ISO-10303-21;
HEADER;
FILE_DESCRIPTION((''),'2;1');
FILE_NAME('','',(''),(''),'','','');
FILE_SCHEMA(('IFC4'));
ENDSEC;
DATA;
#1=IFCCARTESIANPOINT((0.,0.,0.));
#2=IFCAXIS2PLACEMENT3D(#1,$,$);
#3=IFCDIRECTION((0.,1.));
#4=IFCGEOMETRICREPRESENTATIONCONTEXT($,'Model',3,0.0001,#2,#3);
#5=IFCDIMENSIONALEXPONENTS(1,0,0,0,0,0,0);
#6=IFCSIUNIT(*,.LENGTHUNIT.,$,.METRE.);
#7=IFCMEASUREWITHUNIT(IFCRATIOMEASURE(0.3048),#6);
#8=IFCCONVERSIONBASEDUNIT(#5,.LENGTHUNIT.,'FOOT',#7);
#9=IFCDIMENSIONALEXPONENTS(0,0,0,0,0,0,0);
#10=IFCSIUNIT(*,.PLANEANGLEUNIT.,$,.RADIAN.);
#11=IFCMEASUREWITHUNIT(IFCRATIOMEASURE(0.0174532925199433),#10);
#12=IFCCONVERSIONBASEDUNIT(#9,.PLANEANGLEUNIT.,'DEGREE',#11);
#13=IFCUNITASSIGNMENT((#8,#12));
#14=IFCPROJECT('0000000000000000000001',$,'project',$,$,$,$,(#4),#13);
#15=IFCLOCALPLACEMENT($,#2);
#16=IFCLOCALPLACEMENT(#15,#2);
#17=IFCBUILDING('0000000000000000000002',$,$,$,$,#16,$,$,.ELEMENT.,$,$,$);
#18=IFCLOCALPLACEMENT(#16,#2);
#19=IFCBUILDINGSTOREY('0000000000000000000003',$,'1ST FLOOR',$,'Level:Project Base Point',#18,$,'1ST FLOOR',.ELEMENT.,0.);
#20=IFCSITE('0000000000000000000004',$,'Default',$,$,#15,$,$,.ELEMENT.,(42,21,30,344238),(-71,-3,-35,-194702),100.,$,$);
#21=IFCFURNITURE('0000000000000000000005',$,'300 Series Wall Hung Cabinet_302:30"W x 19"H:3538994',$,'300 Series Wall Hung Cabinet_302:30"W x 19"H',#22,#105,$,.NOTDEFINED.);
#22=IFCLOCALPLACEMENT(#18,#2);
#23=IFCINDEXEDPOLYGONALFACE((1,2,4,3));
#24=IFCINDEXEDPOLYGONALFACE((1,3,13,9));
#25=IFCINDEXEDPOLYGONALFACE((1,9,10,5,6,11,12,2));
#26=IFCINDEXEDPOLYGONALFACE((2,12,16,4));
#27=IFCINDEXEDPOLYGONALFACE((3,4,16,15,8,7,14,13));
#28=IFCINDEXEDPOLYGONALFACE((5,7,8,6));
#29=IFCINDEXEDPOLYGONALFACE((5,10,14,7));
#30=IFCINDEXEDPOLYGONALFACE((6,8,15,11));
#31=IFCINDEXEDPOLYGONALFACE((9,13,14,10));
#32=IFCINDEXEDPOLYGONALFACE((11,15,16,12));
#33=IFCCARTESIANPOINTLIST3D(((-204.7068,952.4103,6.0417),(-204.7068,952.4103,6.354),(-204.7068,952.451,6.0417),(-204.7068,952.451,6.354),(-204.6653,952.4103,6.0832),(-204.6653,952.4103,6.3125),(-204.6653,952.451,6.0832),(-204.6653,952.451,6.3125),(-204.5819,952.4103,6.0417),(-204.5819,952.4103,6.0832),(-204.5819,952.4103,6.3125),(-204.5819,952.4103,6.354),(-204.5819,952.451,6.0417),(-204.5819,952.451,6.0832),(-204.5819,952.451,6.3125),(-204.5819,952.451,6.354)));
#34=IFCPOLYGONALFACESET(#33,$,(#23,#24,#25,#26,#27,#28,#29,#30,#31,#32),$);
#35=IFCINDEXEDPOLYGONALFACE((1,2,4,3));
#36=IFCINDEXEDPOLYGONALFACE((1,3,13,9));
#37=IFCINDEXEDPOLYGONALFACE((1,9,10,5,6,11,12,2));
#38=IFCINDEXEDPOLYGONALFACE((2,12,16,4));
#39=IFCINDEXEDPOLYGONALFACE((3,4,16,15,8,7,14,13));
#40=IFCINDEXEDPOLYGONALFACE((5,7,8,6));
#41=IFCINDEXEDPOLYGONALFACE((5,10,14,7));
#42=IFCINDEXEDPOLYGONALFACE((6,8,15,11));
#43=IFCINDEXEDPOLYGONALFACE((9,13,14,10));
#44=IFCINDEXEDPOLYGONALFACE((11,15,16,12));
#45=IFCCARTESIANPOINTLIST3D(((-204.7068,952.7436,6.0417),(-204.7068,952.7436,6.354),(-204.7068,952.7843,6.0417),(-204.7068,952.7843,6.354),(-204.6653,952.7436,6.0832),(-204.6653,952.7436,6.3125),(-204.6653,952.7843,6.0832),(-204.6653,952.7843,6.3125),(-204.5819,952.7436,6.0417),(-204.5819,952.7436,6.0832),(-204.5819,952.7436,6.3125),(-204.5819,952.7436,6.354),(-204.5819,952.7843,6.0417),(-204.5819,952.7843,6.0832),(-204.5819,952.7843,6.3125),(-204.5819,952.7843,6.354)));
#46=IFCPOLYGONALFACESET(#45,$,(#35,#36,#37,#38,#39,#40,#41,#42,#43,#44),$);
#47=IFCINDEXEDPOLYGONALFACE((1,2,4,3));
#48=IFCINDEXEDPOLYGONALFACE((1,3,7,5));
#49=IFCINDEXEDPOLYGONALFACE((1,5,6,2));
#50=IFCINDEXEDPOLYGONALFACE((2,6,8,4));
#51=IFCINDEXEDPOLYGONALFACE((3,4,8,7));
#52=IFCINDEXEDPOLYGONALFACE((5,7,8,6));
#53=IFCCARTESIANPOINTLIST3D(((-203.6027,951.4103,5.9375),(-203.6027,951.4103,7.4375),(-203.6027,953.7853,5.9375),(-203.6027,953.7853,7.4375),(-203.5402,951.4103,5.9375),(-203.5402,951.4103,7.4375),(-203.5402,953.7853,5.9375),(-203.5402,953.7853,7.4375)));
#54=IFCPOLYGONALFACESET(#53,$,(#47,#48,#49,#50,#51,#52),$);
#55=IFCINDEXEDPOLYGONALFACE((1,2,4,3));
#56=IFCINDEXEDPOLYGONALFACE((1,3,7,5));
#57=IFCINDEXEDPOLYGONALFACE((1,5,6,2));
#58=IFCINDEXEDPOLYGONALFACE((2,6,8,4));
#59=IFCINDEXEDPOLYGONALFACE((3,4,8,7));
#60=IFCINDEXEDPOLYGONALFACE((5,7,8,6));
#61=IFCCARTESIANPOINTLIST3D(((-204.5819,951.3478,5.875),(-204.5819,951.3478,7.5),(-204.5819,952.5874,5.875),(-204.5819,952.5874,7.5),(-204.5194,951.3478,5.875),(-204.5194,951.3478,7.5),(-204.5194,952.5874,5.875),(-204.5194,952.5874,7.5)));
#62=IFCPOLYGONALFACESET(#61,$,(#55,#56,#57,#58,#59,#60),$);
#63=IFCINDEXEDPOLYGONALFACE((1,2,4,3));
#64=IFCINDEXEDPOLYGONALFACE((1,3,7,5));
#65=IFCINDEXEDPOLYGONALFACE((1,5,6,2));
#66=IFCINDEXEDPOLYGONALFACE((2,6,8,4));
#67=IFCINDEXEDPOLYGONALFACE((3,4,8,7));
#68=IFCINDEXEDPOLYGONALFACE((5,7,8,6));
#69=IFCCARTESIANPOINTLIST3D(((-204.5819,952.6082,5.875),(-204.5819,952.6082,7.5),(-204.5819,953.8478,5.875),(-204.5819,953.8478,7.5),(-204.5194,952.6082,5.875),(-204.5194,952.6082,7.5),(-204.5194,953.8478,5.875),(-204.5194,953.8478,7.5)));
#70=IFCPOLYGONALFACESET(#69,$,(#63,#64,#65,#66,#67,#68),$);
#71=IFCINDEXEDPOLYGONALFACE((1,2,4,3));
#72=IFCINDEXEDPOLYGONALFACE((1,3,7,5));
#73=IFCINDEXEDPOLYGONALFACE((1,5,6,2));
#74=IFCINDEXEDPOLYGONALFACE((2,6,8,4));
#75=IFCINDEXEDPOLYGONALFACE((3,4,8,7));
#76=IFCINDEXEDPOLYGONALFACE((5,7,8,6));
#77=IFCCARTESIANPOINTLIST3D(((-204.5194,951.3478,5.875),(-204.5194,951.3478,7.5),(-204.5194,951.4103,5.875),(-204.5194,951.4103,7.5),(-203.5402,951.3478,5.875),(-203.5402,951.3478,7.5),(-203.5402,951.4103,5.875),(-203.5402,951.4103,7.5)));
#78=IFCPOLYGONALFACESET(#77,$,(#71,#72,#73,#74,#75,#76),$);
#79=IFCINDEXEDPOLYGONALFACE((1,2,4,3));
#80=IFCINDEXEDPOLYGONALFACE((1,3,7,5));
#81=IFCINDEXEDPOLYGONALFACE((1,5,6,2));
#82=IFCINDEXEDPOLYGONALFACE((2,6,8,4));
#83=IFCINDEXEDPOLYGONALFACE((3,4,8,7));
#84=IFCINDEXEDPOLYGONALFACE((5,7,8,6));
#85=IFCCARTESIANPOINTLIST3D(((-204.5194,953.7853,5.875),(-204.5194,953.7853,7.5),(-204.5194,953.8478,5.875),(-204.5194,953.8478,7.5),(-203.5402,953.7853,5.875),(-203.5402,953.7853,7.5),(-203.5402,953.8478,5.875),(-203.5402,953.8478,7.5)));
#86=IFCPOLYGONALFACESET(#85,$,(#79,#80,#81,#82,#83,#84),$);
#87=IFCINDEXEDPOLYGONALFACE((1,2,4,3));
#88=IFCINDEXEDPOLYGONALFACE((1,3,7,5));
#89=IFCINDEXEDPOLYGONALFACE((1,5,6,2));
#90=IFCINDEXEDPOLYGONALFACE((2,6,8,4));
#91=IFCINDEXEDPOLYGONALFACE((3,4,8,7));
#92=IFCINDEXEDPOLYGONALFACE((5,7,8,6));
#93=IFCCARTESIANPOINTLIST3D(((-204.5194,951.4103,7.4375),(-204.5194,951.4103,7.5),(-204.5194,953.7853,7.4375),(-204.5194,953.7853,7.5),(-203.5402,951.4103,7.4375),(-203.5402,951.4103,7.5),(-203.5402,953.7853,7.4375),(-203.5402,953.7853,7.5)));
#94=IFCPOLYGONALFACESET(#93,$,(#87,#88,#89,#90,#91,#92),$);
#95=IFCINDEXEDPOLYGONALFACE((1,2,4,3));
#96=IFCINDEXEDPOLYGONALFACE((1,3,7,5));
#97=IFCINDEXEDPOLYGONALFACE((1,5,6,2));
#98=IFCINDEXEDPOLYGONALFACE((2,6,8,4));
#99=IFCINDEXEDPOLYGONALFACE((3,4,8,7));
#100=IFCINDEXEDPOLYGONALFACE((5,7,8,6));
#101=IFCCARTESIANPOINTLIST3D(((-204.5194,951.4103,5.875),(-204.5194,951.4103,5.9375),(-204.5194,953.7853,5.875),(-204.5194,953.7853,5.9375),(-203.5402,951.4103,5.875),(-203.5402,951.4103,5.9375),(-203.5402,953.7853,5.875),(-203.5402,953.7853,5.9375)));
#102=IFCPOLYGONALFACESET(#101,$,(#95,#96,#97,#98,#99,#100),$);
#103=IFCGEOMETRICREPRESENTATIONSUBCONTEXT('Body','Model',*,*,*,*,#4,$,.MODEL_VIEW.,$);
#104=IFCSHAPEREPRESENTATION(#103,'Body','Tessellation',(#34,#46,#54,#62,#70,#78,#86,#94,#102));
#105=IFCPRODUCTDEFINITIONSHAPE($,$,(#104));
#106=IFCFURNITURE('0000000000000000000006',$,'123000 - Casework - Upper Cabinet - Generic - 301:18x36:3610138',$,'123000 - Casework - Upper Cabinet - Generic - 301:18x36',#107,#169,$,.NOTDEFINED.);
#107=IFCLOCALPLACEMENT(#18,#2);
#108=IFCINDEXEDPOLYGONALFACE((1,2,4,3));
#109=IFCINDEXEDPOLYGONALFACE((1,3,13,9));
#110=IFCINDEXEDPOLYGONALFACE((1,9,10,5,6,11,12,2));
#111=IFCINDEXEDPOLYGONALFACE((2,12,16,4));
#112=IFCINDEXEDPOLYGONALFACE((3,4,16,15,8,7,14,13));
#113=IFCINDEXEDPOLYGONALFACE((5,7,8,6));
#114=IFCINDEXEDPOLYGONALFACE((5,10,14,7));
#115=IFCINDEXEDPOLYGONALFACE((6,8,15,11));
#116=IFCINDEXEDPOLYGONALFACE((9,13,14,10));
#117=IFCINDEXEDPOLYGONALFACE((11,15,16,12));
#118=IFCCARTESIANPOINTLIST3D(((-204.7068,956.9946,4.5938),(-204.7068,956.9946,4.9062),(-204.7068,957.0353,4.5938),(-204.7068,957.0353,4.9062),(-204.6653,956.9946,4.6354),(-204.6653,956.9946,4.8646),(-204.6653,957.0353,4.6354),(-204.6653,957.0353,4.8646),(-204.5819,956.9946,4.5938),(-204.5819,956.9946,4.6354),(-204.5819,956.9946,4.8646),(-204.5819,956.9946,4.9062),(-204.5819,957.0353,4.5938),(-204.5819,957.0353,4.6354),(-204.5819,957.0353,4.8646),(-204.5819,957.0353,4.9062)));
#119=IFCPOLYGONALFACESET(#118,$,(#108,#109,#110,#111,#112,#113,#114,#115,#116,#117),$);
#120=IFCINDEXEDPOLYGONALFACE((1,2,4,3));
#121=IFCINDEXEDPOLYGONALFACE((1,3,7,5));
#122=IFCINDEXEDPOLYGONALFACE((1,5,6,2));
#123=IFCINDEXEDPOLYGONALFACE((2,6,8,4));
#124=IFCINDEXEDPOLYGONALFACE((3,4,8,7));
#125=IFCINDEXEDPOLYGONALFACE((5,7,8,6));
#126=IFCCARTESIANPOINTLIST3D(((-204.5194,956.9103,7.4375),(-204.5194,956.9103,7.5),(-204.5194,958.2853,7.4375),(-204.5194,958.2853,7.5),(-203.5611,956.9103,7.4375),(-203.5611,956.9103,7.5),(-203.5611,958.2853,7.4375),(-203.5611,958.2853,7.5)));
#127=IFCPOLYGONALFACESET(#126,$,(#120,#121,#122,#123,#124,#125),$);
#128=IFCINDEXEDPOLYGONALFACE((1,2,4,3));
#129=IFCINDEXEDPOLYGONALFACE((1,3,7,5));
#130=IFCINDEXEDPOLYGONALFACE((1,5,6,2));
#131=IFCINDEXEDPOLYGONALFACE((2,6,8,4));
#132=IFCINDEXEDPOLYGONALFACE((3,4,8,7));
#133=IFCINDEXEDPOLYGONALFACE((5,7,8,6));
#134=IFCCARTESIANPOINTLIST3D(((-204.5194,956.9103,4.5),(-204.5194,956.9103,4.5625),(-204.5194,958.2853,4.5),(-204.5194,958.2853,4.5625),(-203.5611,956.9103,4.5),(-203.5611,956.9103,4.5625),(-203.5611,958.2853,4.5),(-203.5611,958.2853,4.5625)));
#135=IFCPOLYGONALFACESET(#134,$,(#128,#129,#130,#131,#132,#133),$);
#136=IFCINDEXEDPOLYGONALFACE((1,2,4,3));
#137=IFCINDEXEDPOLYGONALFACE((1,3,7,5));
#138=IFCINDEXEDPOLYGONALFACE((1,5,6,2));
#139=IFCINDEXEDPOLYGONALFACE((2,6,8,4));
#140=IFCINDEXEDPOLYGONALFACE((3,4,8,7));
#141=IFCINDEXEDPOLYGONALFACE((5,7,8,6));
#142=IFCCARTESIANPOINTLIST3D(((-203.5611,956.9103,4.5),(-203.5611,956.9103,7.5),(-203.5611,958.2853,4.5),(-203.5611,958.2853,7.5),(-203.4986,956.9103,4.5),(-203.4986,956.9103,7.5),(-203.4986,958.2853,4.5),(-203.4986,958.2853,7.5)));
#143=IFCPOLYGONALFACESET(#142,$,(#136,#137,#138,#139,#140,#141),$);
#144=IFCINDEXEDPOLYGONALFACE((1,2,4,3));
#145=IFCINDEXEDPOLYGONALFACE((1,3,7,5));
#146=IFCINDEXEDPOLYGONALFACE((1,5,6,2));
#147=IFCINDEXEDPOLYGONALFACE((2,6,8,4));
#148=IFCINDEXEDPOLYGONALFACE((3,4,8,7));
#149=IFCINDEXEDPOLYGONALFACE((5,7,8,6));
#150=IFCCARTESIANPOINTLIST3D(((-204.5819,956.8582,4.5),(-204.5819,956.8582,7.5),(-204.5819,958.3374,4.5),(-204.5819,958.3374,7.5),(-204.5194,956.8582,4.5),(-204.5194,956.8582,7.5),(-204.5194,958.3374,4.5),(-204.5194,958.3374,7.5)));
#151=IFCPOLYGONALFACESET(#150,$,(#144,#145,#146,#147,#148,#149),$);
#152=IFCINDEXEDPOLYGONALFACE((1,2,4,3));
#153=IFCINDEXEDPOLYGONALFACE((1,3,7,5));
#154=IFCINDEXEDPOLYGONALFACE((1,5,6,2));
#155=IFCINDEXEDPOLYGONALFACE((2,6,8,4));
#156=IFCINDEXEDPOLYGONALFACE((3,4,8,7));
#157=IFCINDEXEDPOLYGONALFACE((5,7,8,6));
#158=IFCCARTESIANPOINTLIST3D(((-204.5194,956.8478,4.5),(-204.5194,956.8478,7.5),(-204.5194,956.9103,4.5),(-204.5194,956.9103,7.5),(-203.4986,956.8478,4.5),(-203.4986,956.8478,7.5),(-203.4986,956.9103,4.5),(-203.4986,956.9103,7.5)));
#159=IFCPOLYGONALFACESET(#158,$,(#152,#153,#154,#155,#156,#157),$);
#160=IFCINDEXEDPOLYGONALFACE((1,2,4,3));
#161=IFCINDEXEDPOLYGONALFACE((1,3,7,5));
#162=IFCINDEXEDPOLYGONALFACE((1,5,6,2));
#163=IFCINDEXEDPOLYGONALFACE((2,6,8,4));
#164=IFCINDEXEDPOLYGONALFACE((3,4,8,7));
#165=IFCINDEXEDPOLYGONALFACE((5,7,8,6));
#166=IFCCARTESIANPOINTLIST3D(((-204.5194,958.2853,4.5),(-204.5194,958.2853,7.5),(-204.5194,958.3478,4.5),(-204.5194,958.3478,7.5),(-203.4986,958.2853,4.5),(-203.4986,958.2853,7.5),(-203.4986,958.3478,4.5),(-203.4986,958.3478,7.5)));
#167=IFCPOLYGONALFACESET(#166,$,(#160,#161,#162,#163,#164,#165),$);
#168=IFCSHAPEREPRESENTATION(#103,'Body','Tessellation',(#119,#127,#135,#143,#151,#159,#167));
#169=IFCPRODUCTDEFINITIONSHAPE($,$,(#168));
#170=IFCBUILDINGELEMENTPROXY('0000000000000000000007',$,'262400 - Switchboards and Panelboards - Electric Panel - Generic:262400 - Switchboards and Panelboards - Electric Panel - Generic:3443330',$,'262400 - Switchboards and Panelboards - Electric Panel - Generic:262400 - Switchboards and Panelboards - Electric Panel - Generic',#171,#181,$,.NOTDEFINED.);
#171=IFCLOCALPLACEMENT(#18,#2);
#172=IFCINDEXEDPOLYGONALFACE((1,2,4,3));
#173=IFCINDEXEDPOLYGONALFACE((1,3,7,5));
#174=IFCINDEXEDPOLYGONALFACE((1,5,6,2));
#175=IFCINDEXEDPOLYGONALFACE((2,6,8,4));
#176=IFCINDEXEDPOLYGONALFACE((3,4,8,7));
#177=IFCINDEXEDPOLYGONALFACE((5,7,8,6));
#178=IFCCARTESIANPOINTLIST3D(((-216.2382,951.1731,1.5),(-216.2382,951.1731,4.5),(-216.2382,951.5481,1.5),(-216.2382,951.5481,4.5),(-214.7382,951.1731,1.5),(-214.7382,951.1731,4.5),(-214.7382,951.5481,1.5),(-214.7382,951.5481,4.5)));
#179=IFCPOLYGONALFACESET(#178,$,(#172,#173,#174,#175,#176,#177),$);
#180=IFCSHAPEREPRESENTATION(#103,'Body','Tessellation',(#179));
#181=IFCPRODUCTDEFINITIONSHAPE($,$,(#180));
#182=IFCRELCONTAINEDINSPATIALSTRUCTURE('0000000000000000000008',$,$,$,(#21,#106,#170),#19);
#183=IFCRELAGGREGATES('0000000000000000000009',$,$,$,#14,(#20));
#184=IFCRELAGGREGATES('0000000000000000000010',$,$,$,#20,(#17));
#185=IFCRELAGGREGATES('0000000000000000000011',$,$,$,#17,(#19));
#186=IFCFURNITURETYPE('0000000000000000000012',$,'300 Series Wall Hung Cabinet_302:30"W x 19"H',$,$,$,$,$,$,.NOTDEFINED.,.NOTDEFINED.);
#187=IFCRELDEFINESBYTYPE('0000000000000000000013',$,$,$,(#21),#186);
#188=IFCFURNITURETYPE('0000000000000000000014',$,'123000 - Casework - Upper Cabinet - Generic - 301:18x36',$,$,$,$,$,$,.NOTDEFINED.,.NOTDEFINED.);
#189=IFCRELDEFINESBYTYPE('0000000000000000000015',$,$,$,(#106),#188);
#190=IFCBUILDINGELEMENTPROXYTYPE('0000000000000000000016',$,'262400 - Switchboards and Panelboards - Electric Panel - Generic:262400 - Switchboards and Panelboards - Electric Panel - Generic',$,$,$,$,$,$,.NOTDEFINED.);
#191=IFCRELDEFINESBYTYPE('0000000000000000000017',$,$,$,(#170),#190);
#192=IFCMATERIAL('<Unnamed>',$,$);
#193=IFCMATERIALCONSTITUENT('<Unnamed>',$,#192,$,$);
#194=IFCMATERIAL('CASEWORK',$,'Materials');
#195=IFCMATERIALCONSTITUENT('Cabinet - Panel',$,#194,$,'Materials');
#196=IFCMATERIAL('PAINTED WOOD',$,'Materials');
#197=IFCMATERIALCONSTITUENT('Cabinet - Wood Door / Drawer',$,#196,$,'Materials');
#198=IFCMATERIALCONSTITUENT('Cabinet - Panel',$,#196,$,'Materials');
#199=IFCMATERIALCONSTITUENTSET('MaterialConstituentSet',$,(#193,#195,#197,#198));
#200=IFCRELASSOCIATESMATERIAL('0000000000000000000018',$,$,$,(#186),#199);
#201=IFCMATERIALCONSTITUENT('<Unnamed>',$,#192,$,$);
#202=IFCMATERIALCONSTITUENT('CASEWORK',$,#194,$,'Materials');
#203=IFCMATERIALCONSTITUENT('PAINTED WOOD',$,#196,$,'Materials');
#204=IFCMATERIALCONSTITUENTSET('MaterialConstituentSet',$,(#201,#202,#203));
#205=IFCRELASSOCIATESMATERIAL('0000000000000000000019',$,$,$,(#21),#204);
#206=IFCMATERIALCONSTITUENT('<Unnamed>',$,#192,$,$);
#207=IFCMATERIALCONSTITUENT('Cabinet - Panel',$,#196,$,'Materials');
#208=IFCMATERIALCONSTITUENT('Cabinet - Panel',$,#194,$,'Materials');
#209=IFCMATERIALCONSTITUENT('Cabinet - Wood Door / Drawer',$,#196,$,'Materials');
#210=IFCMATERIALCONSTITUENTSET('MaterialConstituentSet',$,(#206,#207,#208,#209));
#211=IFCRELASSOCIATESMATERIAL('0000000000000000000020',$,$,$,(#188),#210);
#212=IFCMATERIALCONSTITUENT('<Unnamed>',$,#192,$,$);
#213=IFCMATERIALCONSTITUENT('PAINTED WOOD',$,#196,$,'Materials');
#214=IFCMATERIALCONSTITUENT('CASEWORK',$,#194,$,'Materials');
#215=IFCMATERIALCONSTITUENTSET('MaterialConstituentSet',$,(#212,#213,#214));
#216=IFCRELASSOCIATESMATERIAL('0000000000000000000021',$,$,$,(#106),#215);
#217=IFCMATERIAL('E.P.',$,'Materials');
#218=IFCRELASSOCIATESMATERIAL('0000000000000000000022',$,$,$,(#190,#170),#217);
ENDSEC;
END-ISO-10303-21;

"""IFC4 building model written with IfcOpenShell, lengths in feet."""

from ifc_helpers import new_model, entity, si_unit, converted_unit, direction, frame, frame_2d, origin, origin_2d_with_axis, place, context, subcontext, project, spatial, polyline, rectangle, outline, extrude, source, transform, mapped, material, constituent, constituent_set, type_object, type_shapes, element, save


model = new_model("IFC4")

# Units and contexts
model_context = context("Model", 3, precision=0.0001, world=origin(), true_north=direction((0.0, 1.0)))
body_context = subcontext(model_context, "Body", "Model", "MODEL_VIEW")
ifc_project = project(units=[converted_unit("LENGTHUNIT", "FOOT", entity("IfcRatioMeasure", 0.3048), si_unit("LENGTHUNIT", "METRE"), dimensions=[1, 0, 0, 0, 0, 0, 0]), converted_unit("PLANEANGLEUNIT", "DEGREE", entity("IfcRatioMeasure", 0.0174532925199433), si_unit("PLANEANGLEUNIT", "RADIAN"), dimensions=[0, 0, 0, 0, 0, 0, 0])], contexts=[model_context])

# Site, building, storey
site_placement = place(None, origin())
site = spatial("IfcSite", under=ifc_project, at=site_placement, Name="Default", CompositionType="ELEMENT", RefLatitude=(42, 21, 30, 344238), RefLongitude=(-71, -3, -35, -194702), RefElevation=100.0)
building_placement = place(site_placement, origin())
building = spatial("IfcBuilding", under=site, at=building_placement, CompositionType="ELEMENT")
storey_placement = place(building_placement, origin())
storey = spatial("IfcBuildingStorey", under=building, at=storey_placement, Name="1ST FLOOR", ObjectType="Level:Project Base Point", LongName="1ST FLOOR", CompositionType="ELEMENT", Elevation=0.0)

# Furniture
ifc_material_1 = material(Name="PAINTED WOOD", Category="Materials")
ifc_material_2 = material(Name="CASEWORK", Category="Materials")
ifc_material_3 = material(Name="<Unnamed>")
ifc_constituent_1 = constituent(ifc_material_3, Name="<Unnamed>")
ifc_constituent_2 = constituent(ifc_material_2, Name="CASEWORK", Category="Materials")
ifc_constituent_3 = constituent(ifc_material_1, Name="PAINTED WOOD", Category="Materials")
ifc_constituent_set_1 = constituent_set(constituents=[ifc_constituent_1, ifc_constituent_2, ifc_constituent_3], Name="MaterialConstituentSet")
ifc_constituent_4 = constituent(ifc_material_3, Name="<Unnamed>")
ifc_constituent_5 = constituent(ifc_material_2, Name="Cabinet - Panel", Category="Materials")
ifc_constituent_6 = constituent(ifc_material_1, Name="Cabinet - Wood Door / Drawer", Category="Materials")
ifc_constituent_7 = constituent(ifc_material_1, Name="Cabinet - Panel", Category="Materials")
ifc_constituent_set_2 = constituent_set(constituents=[ifc_constituent_4, ifc_constituent_5, ifc_constituent_6, ifc_constituent_7], Name="MaterialConstituentSet")
furniture_type_1 = type_object("IfcFurnitureType", Name="300 Series Wall Hung Cabinet_302:30\"W x 19\"H", AssemblyPlace="NOTDEFINED", PredefinedType="NOTDEFINED", material=ifc_constituent_set_2)
shared_shape_1 = source(origin(), body_context, "Body", "SweptSolid", [
    extrude(outline(polyline([(-0.0521, -0.1146), (-0.0521, -0.1562), (0.0729, -0.1562), (0.0729, 0.1562), (-0.0521, 0.1562), (-0.0521, 0.1146), (0.0313, 0.1146), (0.0313, -0.1146), (-0.0521, -0.1146)])), frame((1.0625, 1.0937, 0.3229), z_axis=(-1.0, 0.0, 0.0), x_axis=(0.0, 1.0, 0.0)), (0.0, 0.0, -1.0), 0.0407),
    extrude(outline(polyline([(-0.0521, -0.1146), (-0.0521, -0.1562), (0.0729, -0.1562), (0.0729, 0.1562), (-0.0521, 0.1562), (-0.0521, 0.1146), (0.0313, 0.1146), (0.0313, -0.1146), (-0.0521, -0.1146)])), frame((1.3958, 1.0937, 0.3229), z_axis=(-1.0, 0.0, 0.0), x_axis=(0.0, 1.0, 0.0)), (0.0, 0.0, -1.0), 0.0407),
    extrude(rectangle(XDim=0.0625, YDim=2.375, at=frame_2d((0.0, 0.0), x_axis=(1.0, 0.0))), frame((1.25, 0.0313, 0.0625), z_axis=(0.0, 0.0, 1.0), x_axis=(0.0, 1.0, 0.0)), (0.0, 0.0, 1.0), 1.5),
    extrude(rectangle(XDim=0.0625, YDim=1.2396, at=origin_2d_with_axis()), frame((0.6198, 1.0104, 0.0), z_axis=(0.0, 0.0, 1.0), x_axis=(0.0, 1.0, 0.0)), (0.0, 0.0, 1.0), 1.625),
    extrude(rectangle(XDim=0.0625, YDim=1.2396, at=frame_2d((0.0, 0.0), x_axis=(1.0, 0.0))), frame((1.8802, 1.0104, 0.0), z_axis=(0.0, 0.0, 1.0), x_axis=(0.0, 1.0, 0.0)), (0.0, 0.0, 1.0), 1.625),
    extrude(rectangle(XDim=0.0625, YDim=0.9792, at=frame_2d((0.0, 0.0), x_axis=(1.0, 0.0))), frame((0.0313, 0.4896, 0.0)), (0.0, 0.0, 1.0), 1.625),
    extrude(rectangle(XDim=0.0625, YDim=0.9792, at=frame_2d((0.0, 0.0), x_axis=(1.0, 0.0))), frame((2.4688, 0.4896, 0.0)), (0.0, 0.0, 1.0), 1.625),
    extrude(rectangle(XDim=2.375, YDim=0.9792, at=frame_2d((0.0, 0.0), x_axis=(1.0, 0.0))), frame((1.25, 0.4896, 1.5625), z_axis=(0.0, 0.0, 1.0), x_axis=(-1.0, 0.0, 0.0)), (0.0, 0.0, 1.0), 0.0625),
    extrude(rectangle(XDim=2.375, YDim=0.9792, at=frame_2d((0.0, 0.0), x_axis=(1.0, 0.0))), frame((1.25, 0.4896, 0.0), z_axis=(0.0, 0.0, 1.0), x_axis=(-1.0, 0.0, 0.0)), (0.0, 0.0, 1.0), 0.0625),
])
type_shapes(furniture_type_1, [shared_shape_1])
furniture_1_placement = place(storey_placement, frame((-203.5402, 951.3478, 5.875), z_axis=(0.0, 0.0, 1.0), x_axis=(0.0, 1.0, 0.0)))
element("IfcFurniture", 1, at=furniture_1_placement, inside=storey, type_object=furniture_type_1, material=ifc_constituent_set_1, Name="300 Series Wall Hung Cabinet_302:30\"W x 19\"H:3538994", ObjectType="300 Series Wall Hung Cabinet_302:30\"W x 19\"H", PredefinedType="NOTDEFINED", context=body_context, shape_type="MappedRepresentation", body=[
    mapped(shared_shape_1, transform((0.0, 0.0, 0.0), scale=1.0)),
])
ifc_constituent_8 = constituent(ifc_material_3, Name="<Unnamed>")
ifc_constituent_9 = constituent(ifc_material_1, Name="PAINTED WOOD", Category="Materials")
ifc_constituent_10 = constituent(ifc_material_2, Name="CASEWORK", Category="Materials")
ifc_constituent_set_3 = constituent_set(constituents=[ifc_constituent_8, ifc_constituent_9, ifc_constituent_10], Name="MaterialConstituentSet")
ifc_constituent_11 = constituent(ifc_material_3, Name="<Unnamed>")
ifc_constituent_12 = constituent(ifc_material_1, Name="Cabinet - Panel", Category="Materials")
ifc_constituent_13 = constituent(ifc_material_2, Name="Cabinet - Panel", Category="Materials")
ifc_constituent_14 = constituent(ifc_material_1, Name="Cabinet - Wood Door / Drawer", Category="Materials")
ifc_constituent_set_4 = constituent_set(constituents=[ifc_constituent_11, ifc_constituent_12, ifc_constituent_13, ifc_constituent_14], Name="MaterialConstituentSet")
furniture_type_2 = type_object("IfcFurnitureType", Name="123000 - Casework - Upper Cabinet - Generic - 301:18x36", AssemblyPlace="NOTDEFINED", PredefinedType="NOTDEFINED", material=ifc_constituent_set_4)
shared_shape_2 = source(origin(), body_context, "Body", "SweptSolid", [
    extrude(outline(polyline([(-0.0521, -0.1146), (-0.0521, -0.1562), (0.0729, -0.1562), (0.0729, 0.1562), (-0.0521, 0.1562), (-0.0521, 0.1146), (0.0313, 0.1146), (0.0313, -0.1146), (-0.0521, -0.1146)])), frame((0.1468, 1.1354, 0.25), z_axis=(-1.0, 0.0, 0.0), x_axis=(0.0, 1.0, 0.0)), (0.0, 0.0, -1.0), 0.0407),
    extrude(rectangle(XDim=0.9583, YDim=1.375, at=frame_2d((0.0, 0.0), x_axis=(1.0, 0.0))), frame((0.75, 0.5417, 2.9375), z_axis=(0.0, 0.0, 1.0), x_axis=(0.0, 1.0, 0.0)), (0.0, 0.0, 1.0), 0.0625),
    extrude(rectangle(XDim=0.9583, YDim=1.375, at=frame_2d((0.0, 0.0), x_axis=(1.0, 0.0))), frame((0.75, 0.5417, 0.0), z_axis=(0.0, 0.0, 1.0), x_axis=(0.0, 1.0, 0.0)), (0.0, 0.0, 1.0), 0.0625),
    extrude(rectangle(XDim=1.375, YDim=0.0625, at=origin_2d_with_axis()), frame((0.75, 0.0313, 0.0), z_axis=(0.0, 0.0, 1.0), x_axis=(-1.0, 0.0, 0.0)), (0.0, 0.0, 1.0), 3.0),
    extrude(rectangle(XDim=1.4792, YDim=0.0625, at=origin_2d_with_axis()), frame((0.75, 1.0521, 0.0)), (0.0, 0.0, 1.0), 3.0),
    extrude(rectangle(XDim=1.0208, YDim=0.0625, at=origin_2d_with_axis()), frame((0.0312, 0.5104, 0.0), z_axis=(0.0, 0.0, 1.0), x_axis=(0.0, 1.0, 0.0)), (0.0, 0.0, 1.0), 3.0),
    extrude(rectangle(XDim=1.0208, YDim=0.0625, at=origin_2d_with_axis()), frame((1.4688, 0.5104, 0.0), z_axis=(0.0, 0.0, 1.0), x_axis=(0.0, 1.0, 0.0)), (0.0, 0.0, 1.0), 3.0),
])
type_shapes(furniture_type_2, [shared_shape_2])
furniture_2_placement = place(storey_placement, frame((-203.4986, 956.8478, 4.5), z_axis=(0.0, 0.0, 1.0), x_axis=(0.0, 1.0, 0.0)))
element("IfcFurniture", 2, at=furniture_2_placement, inside=storey, type_object=furniture_type_2, material=ifc_constituent_set_3, Name="123000 - Casework - Upper Cabinet - Generic - 301:18x36:3610138", ObjectType="123000 - Casework - Upper Cabinet - Generic - 301:18x36", PredefinedType="NOTDEFINED", context=body_context, shape_type="MappedRepresentation", body=[
    mapped(shared_shape_2, transform((0.0, 0.0, 0.0), scale=1.0)),
])

# Building element proxy
ifc_material_4 = material(Name="E.P.", Category="Materials")
building_element_proxy_type_1 = type_object("IfcBuildingElementProxyType", Name="262400 - Switchboards and Panelboards - Electric Panel - Generic:262400 - Switchboards and Panelboards - Electric Panel - Generic", PredefinedType="NOTDEFINED", material=ifc_material_4)
shared_shape_3 = source(origin(), body_context, "Body", "SweptSolid", [
    extrude(rectangle(XDim=1.5, YDim=0.375, at=origin_2d_with_axis()), frame((0.75, 0.1875, 0.0), z_axis=(0.0, 0.0, 1.0), x_axis=(-1.0, 0.0, 0.0)), (0.0, 0.0, 1.0), 3.0),
])
type_shapes(building_element_proxy_type_1, [shared_shape_3])
proxy_1_placement = place(storey_placement, frame((-214.7382, 951.5481, 1.5), z_axis=(0.0, 0.0, 1.0), x_axis=(-1.0, 0.0, 0.0)))
element("IfcBuildingElementProxy", 3, at=proxy_1_placement, inside=storey, type_object=building_element_proxy_type_1, material=ifc_material_4, Name="262400 - Switchboards and Panelboards - Electric Panel - Generic:262400 - Switchboards and Panelboards - Electric Panel - Generic:3443330", ObjectType="262400 - Switchboards and Panelboards - Electric Panel - Generic:262400 - Switchboards and Panelboards - Electric Panel - Generic", PredefinedType="NOTDEFINED", context=body_context, shape_type="MappedRepresentation", body=[
    mapped(shared_shape_3, transform((0.0, 0.0, 0.0), scale=1.0)),
])

save(model, "model.ifc")
